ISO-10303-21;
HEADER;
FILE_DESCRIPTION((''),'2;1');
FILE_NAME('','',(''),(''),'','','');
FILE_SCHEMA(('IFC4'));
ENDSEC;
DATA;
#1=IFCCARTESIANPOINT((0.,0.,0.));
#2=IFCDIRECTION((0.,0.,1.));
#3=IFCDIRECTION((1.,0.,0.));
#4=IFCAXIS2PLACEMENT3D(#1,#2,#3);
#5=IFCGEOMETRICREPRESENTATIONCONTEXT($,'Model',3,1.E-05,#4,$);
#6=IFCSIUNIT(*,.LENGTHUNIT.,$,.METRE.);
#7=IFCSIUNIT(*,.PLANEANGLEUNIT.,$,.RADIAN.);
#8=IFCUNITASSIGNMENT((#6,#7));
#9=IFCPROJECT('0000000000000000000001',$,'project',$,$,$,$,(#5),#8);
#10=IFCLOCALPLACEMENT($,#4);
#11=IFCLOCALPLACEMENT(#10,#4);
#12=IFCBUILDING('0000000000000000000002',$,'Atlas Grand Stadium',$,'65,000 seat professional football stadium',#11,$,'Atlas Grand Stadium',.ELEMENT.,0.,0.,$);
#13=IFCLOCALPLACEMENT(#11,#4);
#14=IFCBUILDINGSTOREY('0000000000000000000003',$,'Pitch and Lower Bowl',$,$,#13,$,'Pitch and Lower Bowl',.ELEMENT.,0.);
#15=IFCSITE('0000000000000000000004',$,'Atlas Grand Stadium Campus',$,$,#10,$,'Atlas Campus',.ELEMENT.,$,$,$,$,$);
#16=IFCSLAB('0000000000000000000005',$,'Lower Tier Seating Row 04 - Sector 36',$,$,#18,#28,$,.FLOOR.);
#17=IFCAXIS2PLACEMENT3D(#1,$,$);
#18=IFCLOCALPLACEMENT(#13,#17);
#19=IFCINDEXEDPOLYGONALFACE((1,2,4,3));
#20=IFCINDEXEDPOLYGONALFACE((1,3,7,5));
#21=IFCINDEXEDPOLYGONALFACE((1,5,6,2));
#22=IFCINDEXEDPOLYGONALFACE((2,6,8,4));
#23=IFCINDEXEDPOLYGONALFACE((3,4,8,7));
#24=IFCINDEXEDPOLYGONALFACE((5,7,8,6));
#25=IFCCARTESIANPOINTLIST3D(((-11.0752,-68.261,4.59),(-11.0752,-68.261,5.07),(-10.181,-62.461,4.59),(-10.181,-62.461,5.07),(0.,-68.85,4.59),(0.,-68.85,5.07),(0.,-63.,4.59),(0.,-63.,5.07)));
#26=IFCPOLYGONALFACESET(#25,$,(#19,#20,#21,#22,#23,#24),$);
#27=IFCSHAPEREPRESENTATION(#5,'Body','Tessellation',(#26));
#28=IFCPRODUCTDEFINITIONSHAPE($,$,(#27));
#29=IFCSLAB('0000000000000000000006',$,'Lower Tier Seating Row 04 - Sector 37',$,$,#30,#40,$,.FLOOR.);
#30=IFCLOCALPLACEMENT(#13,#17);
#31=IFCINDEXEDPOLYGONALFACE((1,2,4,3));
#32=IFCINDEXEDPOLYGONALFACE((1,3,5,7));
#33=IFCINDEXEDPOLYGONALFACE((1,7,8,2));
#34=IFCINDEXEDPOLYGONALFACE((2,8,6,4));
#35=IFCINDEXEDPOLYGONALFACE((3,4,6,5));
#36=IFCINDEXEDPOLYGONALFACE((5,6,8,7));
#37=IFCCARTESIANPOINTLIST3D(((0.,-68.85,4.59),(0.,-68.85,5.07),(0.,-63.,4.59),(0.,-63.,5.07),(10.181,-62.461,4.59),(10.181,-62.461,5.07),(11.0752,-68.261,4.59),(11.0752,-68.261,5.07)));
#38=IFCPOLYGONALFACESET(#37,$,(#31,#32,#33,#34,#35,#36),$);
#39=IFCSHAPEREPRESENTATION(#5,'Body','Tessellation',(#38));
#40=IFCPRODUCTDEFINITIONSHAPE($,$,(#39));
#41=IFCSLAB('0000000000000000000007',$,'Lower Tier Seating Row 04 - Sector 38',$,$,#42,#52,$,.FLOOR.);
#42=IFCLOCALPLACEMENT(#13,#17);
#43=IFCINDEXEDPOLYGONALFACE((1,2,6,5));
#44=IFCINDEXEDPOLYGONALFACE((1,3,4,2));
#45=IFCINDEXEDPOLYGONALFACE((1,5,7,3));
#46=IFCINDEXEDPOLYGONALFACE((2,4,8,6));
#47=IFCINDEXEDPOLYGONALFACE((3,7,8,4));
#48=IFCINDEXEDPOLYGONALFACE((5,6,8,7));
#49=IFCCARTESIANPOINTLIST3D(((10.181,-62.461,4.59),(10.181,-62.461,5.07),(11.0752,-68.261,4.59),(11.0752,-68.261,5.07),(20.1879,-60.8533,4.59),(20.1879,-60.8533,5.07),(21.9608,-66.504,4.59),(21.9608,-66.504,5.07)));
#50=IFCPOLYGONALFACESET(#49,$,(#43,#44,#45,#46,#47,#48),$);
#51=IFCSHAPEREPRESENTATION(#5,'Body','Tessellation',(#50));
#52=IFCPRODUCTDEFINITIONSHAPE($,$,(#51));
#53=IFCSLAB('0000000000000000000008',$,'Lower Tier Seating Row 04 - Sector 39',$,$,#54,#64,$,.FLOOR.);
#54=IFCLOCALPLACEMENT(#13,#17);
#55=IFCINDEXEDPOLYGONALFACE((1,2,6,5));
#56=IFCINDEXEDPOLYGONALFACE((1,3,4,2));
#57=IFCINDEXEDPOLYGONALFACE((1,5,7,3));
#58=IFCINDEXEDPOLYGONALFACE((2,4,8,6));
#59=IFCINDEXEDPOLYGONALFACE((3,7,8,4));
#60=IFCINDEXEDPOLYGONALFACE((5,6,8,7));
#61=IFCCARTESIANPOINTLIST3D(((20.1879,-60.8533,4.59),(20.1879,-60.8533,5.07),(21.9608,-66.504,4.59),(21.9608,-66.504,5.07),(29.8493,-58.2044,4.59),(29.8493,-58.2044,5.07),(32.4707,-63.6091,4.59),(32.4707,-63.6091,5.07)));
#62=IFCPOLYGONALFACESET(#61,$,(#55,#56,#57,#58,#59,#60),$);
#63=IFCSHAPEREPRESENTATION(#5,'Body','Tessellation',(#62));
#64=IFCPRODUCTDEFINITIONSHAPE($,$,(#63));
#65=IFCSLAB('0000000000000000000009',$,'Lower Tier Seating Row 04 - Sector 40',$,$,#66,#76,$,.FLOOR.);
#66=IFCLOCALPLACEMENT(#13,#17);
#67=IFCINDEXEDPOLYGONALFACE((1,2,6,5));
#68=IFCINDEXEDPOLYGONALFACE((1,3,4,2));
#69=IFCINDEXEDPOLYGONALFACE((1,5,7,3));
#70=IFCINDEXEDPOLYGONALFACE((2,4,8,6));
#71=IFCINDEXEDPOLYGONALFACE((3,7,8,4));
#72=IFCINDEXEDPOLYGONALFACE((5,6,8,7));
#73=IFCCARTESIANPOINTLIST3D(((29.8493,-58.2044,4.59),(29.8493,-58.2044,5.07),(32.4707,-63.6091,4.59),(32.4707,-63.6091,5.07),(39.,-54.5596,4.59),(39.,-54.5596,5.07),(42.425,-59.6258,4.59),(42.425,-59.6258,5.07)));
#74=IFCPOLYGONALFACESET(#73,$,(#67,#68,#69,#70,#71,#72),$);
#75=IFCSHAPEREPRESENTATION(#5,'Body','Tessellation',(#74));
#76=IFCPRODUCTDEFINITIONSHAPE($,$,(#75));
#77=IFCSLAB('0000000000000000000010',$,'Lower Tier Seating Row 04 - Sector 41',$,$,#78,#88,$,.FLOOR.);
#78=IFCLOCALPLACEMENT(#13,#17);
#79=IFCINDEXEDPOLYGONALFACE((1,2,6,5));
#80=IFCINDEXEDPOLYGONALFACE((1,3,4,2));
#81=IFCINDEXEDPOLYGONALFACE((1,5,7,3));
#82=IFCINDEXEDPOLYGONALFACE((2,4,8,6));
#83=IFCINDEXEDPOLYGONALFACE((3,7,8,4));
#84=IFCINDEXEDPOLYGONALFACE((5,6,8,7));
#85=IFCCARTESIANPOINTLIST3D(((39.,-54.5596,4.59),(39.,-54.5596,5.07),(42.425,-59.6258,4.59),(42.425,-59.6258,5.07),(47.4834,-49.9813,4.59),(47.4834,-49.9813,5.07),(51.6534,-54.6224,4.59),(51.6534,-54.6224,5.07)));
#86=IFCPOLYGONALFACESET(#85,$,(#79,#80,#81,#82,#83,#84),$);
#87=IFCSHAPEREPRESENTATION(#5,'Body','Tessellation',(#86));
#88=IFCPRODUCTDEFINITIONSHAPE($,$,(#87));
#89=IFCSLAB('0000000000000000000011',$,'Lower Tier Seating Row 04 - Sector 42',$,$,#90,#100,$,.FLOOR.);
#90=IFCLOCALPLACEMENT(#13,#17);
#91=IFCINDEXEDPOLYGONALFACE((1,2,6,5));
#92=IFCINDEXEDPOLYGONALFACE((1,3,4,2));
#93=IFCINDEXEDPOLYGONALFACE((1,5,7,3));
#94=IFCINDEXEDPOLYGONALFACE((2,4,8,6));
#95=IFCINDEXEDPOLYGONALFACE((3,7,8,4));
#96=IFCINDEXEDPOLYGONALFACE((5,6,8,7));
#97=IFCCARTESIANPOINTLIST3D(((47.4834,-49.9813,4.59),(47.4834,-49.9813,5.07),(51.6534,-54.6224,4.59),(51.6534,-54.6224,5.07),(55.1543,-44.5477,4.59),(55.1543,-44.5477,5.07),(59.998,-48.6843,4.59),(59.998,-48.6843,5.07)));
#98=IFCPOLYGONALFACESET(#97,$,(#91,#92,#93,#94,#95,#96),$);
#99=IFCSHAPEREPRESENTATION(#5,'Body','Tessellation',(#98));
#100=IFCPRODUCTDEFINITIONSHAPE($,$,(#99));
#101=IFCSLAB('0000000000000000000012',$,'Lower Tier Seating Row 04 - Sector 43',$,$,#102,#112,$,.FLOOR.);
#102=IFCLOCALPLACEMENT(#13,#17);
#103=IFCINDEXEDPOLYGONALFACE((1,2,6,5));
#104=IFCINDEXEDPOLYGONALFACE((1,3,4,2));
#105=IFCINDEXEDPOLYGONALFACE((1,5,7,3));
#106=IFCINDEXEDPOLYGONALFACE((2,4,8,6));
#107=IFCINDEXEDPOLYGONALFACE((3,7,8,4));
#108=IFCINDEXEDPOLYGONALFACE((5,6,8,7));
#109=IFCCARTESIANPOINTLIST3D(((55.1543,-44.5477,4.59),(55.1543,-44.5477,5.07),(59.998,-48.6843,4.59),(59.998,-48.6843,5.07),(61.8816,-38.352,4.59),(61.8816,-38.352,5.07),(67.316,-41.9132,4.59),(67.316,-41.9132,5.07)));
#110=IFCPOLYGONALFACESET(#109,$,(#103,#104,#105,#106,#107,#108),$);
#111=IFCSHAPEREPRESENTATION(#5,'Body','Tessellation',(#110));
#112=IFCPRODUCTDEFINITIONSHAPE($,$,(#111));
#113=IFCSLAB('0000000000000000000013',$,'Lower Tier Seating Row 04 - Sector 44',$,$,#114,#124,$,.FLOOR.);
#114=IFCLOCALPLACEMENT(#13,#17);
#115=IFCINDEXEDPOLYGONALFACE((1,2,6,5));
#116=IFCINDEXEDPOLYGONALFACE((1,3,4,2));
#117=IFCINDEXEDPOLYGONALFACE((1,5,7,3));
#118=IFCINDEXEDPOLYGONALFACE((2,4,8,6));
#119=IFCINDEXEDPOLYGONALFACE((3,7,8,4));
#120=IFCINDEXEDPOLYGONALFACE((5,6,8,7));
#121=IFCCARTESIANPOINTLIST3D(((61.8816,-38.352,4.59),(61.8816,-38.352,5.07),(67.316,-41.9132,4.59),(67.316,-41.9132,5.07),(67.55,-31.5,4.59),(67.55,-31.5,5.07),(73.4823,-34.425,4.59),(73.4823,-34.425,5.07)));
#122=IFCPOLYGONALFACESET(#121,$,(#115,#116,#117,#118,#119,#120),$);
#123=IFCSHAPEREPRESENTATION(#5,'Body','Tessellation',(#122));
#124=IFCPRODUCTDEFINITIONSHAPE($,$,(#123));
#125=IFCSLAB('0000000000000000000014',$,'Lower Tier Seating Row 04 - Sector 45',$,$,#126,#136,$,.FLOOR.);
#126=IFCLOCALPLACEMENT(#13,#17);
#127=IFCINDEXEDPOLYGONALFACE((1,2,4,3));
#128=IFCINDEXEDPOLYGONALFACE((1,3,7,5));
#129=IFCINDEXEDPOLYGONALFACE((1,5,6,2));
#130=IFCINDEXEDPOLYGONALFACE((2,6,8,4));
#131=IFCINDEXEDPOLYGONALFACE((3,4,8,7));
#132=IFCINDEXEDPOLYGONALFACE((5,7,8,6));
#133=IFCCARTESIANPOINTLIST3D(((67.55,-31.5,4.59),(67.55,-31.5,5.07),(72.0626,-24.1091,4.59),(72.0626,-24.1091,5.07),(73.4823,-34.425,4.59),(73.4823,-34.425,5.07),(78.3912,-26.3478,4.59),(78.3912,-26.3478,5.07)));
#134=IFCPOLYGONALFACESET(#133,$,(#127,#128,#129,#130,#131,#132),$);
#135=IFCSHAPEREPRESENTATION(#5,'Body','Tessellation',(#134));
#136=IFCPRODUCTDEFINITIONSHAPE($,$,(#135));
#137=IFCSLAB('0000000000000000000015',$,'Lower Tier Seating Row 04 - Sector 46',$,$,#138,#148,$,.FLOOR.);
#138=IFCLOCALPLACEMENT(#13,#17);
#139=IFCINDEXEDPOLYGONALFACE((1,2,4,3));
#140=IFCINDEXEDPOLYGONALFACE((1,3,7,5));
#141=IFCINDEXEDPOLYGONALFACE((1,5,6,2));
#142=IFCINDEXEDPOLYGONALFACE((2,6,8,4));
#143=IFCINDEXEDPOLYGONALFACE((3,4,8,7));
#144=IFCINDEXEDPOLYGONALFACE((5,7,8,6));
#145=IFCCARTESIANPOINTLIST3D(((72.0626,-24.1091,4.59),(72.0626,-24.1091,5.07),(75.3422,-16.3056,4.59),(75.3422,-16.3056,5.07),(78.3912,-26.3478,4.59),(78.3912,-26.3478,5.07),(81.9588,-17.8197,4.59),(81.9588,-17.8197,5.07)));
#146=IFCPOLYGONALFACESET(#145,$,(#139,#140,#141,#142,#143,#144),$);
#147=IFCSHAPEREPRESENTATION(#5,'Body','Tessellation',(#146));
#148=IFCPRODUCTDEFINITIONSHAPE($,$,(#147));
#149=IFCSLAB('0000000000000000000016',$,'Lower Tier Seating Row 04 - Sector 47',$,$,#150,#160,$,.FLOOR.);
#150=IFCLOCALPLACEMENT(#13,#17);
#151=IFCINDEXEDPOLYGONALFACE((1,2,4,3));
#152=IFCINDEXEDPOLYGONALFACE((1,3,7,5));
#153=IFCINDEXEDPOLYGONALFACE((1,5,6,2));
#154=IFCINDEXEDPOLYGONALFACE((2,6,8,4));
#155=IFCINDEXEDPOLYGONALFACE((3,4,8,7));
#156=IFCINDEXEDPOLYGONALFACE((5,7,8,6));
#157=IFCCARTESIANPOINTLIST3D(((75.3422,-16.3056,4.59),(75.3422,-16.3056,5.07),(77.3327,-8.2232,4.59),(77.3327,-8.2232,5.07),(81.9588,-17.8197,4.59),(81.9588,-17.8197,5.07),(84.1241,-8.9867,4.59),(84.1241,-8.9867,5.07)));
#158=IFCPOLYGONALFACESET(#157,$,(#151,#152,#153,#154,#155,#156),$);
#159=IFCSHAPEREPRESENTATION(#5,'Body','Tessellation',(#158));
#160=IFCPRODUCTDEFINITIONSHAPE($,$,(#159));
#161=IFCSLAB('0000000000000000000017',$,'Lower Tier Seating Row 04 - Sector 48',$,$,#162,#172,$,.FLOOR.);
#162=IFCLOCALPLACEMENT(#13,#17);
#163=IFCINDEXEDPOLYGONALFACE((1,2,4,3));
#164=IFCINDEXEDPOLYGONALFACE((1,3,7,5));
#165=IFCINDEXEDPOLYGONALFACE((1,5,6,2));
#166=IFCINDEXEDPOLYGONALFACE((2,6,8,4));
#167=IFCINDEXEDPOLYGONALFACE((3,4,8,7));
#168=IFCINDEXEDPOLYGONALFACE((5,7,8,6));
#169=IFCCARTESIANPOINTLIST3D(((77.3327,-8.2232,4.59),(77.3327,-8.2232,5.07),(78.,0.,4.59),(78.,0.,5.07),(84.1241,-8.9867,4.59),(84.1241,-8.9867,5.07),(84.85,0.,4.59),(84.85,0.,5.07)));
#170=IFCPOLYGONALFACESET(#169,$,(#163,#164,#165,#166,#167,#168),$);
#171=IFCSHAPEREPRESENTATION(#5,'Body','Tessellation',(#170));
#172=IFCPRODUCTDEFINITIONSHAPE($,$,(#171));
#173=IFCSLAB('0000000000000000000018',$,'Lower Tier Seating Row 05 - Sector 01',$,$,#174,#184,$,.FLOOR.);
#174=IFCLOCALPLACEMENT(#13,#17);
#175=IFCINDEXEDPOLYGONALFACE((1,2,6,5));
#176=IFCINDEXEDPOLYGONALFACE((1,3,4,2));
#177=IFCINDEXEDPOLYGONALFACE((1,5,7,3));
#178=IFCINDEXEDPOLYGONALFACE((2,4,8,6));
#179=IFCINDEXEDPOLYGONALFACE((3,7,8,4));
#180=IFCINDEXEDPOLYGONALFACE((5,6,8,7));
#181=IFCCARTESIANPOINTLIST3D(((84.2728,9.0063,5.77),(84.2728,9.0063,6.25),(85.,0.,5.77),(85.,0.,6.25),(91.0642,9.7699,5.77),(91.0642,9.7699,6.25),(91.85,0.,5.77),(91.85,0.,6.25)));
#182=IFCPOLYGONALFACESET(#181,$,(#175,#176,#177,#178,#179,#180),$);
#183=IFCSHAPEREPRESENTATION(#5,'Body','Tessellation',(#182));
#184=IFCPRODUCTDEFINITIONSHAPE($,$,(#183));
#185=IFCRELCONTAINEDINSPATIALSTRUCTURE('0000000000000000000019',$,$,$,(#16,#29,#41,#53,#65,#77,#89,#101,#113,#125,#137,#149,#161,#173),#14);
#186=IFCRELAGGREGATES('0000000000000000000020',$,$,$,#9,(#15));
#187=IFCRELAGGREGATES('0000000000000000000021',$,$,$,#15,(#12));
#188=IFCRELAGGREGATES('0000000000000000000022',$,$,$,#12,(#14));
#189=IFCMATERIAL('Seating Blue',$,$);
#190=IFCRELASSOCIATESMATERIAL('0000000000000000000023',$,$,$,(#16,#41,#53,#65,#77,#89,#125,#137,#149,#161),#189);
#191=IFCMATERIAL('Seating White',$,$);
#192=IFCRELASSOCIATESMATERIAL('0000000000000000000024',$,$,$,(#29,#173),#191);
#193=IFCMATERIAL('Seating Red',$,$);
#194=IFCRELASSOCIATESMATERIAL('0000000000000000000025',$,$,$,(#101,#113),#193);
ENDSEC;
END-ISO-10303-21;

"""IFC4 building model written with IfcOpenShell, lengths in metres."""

from ifc_helpers import new_model, si_unit, frame, origin_with_axes, place, context, project, spatial, polyline, outline, extrude, material, element, save


model = new_model("IFC4")

# Units and contexts
model_context = context("Model", 3, precision=1e-05, world=origin_with_axes())
ifc_project = project(units=[si_unit("LENGTHUNIT", "METRE"), si_unit("PLANEANGLEUNIT", "RADIAN")], contexts=[model_context])

# Site, building, storey
site_placement = place(None, origin_with_axes())
site = spatial("IfcSite", under=ifc_project, at=site_placement, Name="Atlas Grand Stadium Campus", LongName="Atlas Campus", CompositionType="ELEMENT")
building_placement = place(site_placement, origin_with_axes())
building = spatial("IfcBuilding", under=site, at=building_placement, Name="Atlas Grand Stadium", ObjectType="65,000 seat professional football stadium", LongName="Atlas Grand Stadium", CompositionType="ELEMENT", ElevationOfRefHeight=0.0, ElevationOfTerrain=0.0)
storey_placement = place(building_placement, origin_with_axes())
storey = spatial("IfcBuildingStorey", under=building, at=storey_placement, Name="Pitch and Lower Bowl", LongName="Pitch and Lower Bowl", CompositionType="ELEMENT", Elevation=0.0)

# Slabs
ifc_material_1 = material(Name="Seating Blue")
ifc_material_2 = material(Name="Seating White")
ifc_material_3 = material(Name="Seating Red")
slab_1_placement = place(storey_placement, frame((0.0, 0.0, 4.59), z_axis=(0.0, 0.0, 1.0), x_axis=(1.0, 0.0, 0.0)))
element("IfcSlab", 1, at=slab_1_placement, inside=storey, material=ifc_material_1, Name="Lower Tier Seating Row 04 - Sector 36", PredefinedType="FLOOR", context=model_context, shape_type="SweptSolid", body=[
    extrude(outline(polyline([(-11.0752, -68.261), (0.0, -68.85), (0.0, -63.0), (-10.181, -62.461), (-11.0752, -68.261)])), origin_with_axes(), (0.0, 0.0, 1.0), 0.48),
])
slab_2_placement = place(storey_placement, frame((0.0, 0.0, 4.59), z_axis=(0.0, 0.0, 1.0), x_axis=(1.0, 0.0, 0.0)))
element("IfcSlab", 2, at=slab_2_placement, inside=storey, material=ifc_material_2, Name="Lower Tier Seating Row 04 - Sector 37", PredefinedType="FLOOR", context=model_context, shape_type="SweptSolid", body=[
    extrude(outline(polyline([(0.0, -68.85), (11.0752, -68.261), (10.181, -62.461), (0.0, -63.0), (0.0, -68.85)])), origin_with_axes(), (0.0, 0.0, 1.0), 0.48),
])
slab_3_placement = place(storey_placement, frame((0.0, 0.0, 4.59), z_axis=(0.0, 0.0, 1.0), x_axis=(1.0, 0.0, 0.0)))
element("IfcSlab", 3, at=slab_3_placement, inside=storey, material=ifc_material_1, Name="Lower Tier Seating Row 04 - Sector 38", PredefinedType="FLOOR", context=model_context, shape_type="SweptSolid", body=[
    extrude(outline(polyline([(11.0752, -68.261), (21.9608, -66.504), (20.1879, -60.8533), (10.181, -62.461), (11.0752, -68.261)])), origin_with_axes(), (0.0, 0.0, 1.0), 0.48),
])
slab_4_placement = place(storey_placement, frame((0.0, 0.0, 4.59), z_axis=(0.0, 0.0, 1.0), x_axis=(1.0, 0.0, 0.0)))
element("IfcSlab", 4, at=slab_4_placement, inside=storey, material=ifc_material_1, Name="Lower Tier Seating Row 04 - Sector 39", PredefinedType="FLOOR", context=model_context, shape_type="SweptSolid", body=[
    extrude(outline(polyline([(21.9608, -66.504), (32.4707, -63.6091), (29.8493, -58.2044), (20.1879, -60.8533), (21.9608, -66.504)])), origin_with_axes(), (0.0, 0.0, 1.0), 0.48),
])
slab_5_placement = place(storey_placement, frame((0.0, 0.0, 4.59), z_axis=(0.0, 0.0, 1.0), x_axis=(1.0, 0.0, 0.0)))
element("IfcSlab", 5, at=slab_5_placement, inside=storey, material=ifc_material_1, Name="Lower Tier Seating Row 04 - Sector 40", PredefinedType="FLOOR", context=model_context, shape_type="SweptSolid", body=[
    extrude(outline(polyline([(32.4707, -63.6091), (42.425, -59.6258), (39.0, -54.5596), (29.8493, -58.2044), (32.4707, -63.6091)])), origin_with_axes(), (0.0, 0.0, 1.0), 0.48),
])
slab_6_placement = place(storey_placement, frame((0.0, 0.0, 4.59), z_axis=(0.0, 0.0, 1.0), x_axis=(1.0, 0.0, 0.0)))
element("IfcSlab", 6, at=slab_6_placement, inside=storey, material=ifc_material_1, Name="Lower Tier Seating Row 04 - Sector 41", PredefinedType="FLOOR", context=model_context, shape_type="SweptSolid", body=[
    extrude(outline(polyline([(42.425, -59.6258), (51.6534, -54.6224), (47.4834, -49.9813), (39.0, -54.5596), (42.425, -59.6258)])), origin_with_axes(), (0.0, 0.0, 1.0), 0.48),
])
slab_7_placement = place(storey_placement, frame((0.0, 0.0, 4.59), z_axis=(0.0, 0.0, 1.0), x_axis=(1.0, 0.0, 0.0)))
element("IfcSlab", 7, at=slab_7_placement, inside=storey, material=ifc_material_1, Name="Lower Tier Seating Row 04 - Sector 42", PredefinedType="FLOOR", context=model_context, shape_type="SweptSolid", body=[
    extrude(outline(polyline([(51.6534, -54.6224), (59.998, -48.6843), (55.1543, -44.5477), (47.4834, -49.9813), (51.6534, -54.6224)])), origin_with_axes(), (0.0, 0.0, 1.0), 0.48),
])
slab_8_placement = place(storey_placement, frame((0.0, 0.0, 4.59), z_axis=(0.0, 0.0, 1.0), x_axis=(1.0, 0.0, 0.0)))
element("IfcSlab", 8, at=slab_8_placement, inside=storey, material=ifc_material_3, Name="Lower Tier Seating Row 04 - Sector 43", PredefinedType="FLOOR", context=model_context, shape_type="SweptSolid", body=[
    extrude(outline(polyline([(59.998, -48.6843), (67.316, -41.9132), (61.8816, -38.352), (55.1543, -44.5477), (59.998, -48.6843)])), origin_with_axes(), (0.0, 0.0, 1.0), 0.48),
])
slab_9_placement = place(storey_placement, frame((0.0, 0.0, 4.59), z_axis=(0.0, 0.0, 1.0), x_axis=(1.0, 0.0, 0.0)))
element("IfcSlab", 9, at=slab_9_placement, inside=storey, material=ifc_material_3, Name="Lower Tier Seating Row 04 - Sector 44", PredefinedType="FLOOR", context=model_context, shape_type="SweptSolid", body=[
    extrude(outline(polyline([(67.316, -41.9132), (73.4823, -34.425), (67.55, -31.5), (61.8816, -38.352), (67.316, -41.9132)])), origin_with_axes(), (0.0, 0.0, 1.0), 0.48),
])
slab_10_placement = place(storey_placement, frame((0.0, 0.0, 4.59), z_axis=(0.0, 0.0, 1.0), x_axis=(1.0, 0.0, 0.0)))
element("IfcSlab", 10, at=slab_10_placement, inside=storey, material=ifc_material_1, Name="Lower Tier Seating Row 04 - Sector 45", PredefinedType="FLOOR", context=model_context, shape_type="SweptSolid", body=[
    extrude(outline(polyline([(73.4823, -34.425), (78.3912, -26.3478), (72.0626, -24.1091), (67.55, -31.5), (73.4823, -34.425)])), origin_with_axes(), (0.0, 0.0, 1.0), 0.48),
])
slab_11_placement = place(storey_placement, frame((0.0, 0.0, 4.59), z_axis=(0.0, 0.0, 1.0), x_axis=(1.0, 0.0, 0.0)))
element("IfcSlab", 11, at=slab_11_placement, inside=storey, material=ifc_material_1, Name="Lower Tier Seating Row 04 - Sector 46", PredefinedType="FLOOR", context=model_context, shape_type="SweptSolid", body=[
    extrude(outline(polyline([(78.3912, -26.3478), (81.9588, -17.8197), (75.3422, -16.3056), (72.0626, -24.1091), (78.3912, -26.3478)])), origin_with_axes(), (0.0, 0.0, 1.0), 0.48),
])
slab_12_placement = place(storey_placement, frame((0.0, 0.0, 4.59), z_axis=(0.0, 0.0, 1.0), x_axis=(1.0, 0.0, 0.0)))
element("IfcSlab", 12, at=slab_12_placement, inside=storey, material=ifc_material_1, Name="Lower Tier Seating Row 04 - Sector 47", PredefinedType="FLOOR", context=model_context, shape_type="SweptSolid", body=[
    extrude(outline(polyline([(81.9588, -17.8197), (84.1241, -8.9867), (77.3327, -8.2232), (75.3422, -16.3056), (81.9588, -17.8197)])), origin_with_axes(), (0.0, 0.0, 1.0), 0.48),
])
slab_13_placement = place(storey_placement, frame((0.0, 0.0, 4.59), z_axis=(0.0, 0.0, 1.0), x_axis=(1.0, 0.0, 0.0)))
element("IfcSlab", 13, at=slab_13_placement, inside=storey, material=ifc_material_1, Name="Lower Tier Seating Row 04 - Sector 48", PredefinedType="FLOOR", context=model_context, shape_type="SweptSolid", body=[
    extrude(outline(polyline([(84.1241, -8.9867), (84.85, 0.0), (78.0, 0.0), (77.3327, -8.2232), (84.1241, -8.9867)])), origin_with_axes(), (0.0, 0.0, 1.0), 0.48),
])
slab_14_placement = place(storey_placement, frame((0.0, 0.0, 5.77), z_axis=(0.0, 0.0, 1.0), x_axis=(1.0, 0.0, 0.0)))
element("IfcSlab", 14, at=slab_14_placement, inside=storey, material=ifc_material_2, Name="Lower Tier Seating Row 05 - Sector 01", PredefinedType="FLOOR", context=model_context, shape_type="SweptSolid", body=[
    extrude(outline(polyline([(91.85, 0.0), (91.0642, 9.7699), (84.2728, 9.0063), (85.0, 0.0), (91.85, 0.0)])), origin_with_axes(), (0.0, 0.0, 1.0), 0.48),
])

save(model, "model.ifc")
